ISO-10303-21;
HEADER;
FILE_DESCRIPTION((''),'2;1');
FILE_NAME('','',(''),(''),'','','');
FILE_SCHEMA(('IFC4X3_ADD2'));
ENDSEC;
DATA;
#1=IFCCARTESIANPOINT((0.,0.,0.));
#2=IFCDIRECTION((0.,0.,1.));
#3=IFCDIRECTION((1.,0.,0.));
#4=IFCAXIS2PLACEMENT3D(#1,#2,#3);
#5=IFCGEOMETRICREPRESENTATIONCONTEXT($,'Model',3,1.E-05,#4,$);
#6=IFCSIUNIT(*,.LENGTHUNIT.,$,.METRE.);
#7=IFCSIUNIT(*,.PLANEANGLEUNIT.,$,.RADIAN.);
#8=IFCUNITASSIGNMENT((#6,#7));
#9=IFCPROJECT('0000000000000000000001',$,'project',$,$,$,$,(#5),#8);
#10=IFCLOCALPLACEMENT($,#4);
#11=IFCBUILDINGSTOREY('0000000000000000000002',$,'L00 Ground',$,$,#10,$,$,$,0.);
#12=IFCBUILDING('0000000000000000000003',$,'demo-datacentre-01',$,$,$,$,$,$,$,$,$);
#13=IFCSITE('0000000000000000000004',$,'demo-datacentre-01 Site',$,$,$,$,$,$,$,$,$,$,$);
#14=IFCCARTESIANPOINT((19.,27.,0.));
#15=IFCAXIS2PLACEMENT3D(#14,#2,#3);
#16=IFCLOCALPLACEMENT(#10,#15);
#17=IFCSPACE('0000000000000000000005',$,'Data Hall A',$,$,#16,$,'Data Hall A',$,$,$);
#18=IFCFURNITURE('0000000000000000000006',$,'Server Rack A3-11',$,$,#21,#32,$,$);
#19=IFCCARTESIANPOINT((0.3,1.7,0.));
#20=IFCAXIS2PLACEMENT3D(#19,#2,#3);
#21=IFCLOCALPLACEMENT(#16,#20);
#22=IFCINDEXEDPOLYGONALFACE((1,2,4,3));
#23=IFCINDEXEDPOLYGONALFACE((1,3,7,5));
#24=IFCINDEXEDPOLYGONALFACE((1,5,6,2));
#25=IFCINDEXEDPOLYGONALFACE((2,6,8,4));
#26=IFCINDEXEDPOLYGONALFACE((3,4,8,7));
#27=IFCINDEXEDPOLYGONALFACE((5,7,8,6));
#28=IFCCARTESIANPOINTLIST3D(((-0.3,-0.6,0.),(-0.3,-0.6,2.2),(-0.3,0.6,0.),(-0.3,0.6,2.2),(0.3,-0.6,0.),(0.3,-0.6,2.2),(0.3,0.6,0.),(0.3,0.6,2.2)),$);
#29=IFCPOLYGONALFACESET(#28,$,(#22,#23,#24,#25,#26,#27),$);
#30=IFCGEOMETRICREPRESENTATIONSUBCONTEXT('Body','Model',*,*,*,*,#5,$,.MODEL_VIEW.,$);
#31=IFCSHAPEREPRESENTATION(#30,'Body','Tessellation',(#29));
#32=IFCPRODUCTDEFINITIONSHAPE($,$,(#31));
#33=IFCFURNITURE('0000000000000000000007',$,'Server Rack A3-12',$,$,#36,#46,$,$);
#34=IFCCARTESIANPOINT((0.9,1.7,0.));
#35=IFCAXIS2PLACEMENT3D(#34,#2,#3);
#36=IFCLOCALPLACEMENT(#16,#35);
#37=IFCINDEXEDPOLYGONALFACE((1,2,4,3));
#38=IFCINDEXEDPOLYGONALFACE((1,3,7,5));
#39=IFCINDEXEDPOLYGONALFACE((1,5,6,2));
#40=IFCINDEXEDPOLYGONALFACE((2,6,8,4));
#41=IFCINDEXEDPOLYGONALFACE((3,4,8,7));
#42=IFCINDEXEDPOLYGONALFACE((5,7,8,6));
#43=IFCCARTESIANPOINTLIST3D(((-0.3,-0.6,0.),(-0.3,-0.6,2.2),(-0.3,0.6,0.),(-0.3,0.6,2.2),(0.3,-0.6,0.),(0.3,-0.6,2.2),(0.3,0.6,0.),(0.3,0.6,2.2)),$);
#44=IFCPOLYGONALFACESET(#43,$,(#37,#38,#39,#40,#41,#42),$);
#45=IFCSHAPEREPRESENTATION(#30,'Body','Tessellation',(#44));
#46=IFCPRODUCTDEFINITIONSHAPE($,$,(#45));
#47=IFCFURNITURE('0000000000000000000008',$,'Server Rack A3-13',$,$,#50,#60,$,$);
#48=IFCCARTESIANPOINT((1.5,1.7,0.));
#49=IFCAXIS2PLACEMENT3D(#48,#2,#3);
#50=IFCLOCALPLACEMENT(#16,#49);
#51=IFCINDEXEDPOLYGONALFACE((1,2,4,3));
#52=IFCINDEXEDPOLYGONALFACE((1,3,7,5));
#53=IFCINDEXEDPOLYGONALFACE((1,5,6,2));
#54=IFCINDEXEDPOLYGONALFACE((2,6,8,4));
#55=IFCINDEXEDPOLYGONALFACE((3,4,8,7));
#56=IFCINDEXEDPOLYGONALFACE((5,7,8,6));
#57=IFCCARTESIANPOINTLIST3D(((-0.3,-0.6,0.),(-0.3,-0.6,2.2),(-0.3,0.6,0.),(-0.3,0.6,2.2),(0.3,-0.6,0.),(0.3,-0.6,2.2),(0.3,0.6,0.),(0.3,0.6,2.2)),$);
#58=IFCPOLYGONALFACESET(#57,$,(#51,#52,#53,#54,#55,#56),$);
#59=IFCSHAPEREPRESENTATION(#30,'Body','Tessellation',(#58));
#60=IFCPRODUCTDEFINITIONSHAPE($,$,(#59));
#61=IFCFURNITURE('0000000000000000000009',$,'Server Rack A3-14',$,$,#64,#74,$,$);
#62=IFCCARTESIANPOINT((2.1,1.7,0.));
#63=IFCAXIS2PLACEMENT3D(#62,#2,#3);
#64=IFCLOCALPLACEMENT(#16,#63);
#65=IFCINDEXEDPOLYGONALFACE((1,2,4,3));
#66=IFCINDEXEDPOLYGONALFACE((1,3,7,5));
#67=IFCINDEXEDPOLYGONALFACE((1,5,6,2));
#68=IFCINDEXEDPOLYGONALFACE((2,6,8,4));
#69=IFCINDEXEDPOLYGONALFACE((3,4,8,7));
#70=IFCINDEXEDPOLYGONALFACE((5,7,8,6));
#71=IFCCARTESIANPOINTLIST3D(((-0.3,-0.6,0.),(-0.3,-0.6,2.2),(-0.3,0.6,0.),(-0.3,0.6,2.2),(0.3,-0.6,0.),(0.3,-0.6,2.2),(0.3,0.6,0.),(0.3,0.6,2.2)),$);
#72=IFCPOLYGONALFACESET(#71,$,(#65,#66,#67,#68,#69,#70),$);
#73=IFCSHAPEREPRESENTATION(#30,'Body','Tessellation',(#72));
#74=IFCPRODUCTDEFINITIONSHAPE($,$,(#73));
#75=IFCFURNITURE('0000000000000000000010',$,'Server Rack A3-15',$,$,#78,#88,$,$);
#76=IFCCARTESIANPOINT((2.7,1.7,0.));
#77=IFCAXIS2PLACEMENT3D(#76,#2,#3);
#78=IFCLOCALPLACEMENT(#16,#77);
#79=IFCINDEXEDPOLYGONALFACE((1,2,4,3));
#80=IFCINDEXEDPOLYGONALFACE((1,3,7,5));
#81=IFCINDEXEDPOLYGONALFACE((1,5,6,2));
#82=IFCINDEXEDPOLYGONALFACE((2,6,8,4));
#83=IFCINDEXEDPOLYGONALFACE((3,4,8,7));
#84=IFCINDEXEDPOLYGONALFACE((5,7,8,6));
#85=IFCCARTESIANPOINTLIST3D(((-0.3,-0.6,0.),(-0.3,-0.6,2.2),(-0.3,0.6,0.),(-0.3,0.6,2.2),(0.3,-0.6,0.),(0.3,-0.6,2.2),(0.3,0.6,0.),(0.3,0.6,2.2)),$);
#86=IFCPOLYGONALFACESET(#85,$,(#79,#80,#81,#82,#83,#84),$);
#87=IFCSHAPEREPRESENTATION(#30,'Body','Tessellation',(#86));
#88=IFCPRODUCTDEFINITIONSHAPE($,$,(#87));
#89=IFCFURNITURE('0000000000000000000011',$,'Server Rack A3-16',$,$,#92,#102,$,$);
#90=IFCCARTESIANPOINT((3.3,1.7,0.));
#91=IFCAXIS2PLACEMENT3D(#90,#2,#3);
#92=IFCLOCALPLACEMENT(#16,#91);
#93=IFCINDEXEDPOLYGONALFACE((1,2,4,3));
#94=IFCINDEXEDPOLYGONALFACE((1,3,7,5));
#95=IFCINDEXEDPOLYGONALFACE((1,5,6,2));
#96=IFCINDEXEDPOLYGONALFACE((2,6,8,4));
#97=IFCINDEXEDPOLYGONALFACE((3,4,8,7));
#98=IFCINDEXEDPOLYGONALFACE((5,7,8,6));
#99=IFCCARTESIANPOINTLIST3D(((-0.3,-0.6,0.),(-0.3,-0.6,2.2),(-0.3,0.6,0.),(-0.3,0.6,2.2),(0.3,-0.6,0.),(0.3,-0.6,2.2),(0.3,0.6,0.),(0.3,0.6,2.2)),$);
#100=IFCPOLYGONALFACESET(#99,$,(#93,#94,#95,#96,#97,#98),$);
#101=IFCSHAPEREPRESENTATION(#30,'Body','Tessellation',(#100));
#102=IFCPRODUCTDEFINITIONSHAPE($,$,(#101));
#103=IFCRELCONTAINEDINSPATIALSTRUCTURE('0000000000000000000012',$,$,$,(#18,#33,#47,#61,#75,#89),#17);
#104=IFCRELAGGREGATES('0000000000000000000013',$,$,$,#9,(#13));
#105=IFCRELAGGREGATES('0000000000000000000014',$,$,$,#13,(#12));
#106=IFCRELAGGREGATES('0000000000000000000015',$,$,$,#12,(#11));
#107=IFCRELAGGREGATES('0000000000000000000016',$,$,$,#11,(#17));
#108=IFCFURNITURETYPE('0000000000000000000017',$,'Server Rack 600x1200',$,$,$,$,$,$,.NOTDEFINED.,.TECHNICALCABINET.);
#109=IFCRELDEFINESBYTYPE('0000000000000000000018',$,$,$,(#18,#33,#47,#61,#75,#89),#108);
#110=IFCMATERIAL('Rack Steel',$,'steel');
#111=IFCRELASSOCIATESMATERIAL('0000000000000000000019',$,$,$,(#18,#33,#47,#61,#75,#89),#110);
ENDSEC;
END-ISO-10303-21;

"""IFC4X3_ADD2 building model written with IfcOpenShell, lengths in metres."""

from ifc_helpers import new_model, si_unit, frame, origin_with_axes, place, context, subcontext, project, spatial, rectangle, extrude, material, type_object, element, save


model = new_model("IFC4X3_ADD2")

# Units and contexts
model_context = context("Model", 3, precision=1e-05, world=origin_with_axes())
body_context = subcontext(model_context, "Body", "Model", "MODEL_VIEW")
ifc_project = project(units=[si_unit("LENGTHUNIT", "METRE"), si_unit("PLANEANGLEUNIT", "RADIAN")], contexts=[model_context])

# Site, building, storey
site = spatial("IfcSite", under=ifc_project, Name="demo-datacentre-01 Site")
building = spatial("IfcBuilding", under=site, Name="demo-datacentre-01")
storey_placement = place(None, origin_with_axes())
storey = spatial("IfcBuildingStorey", under=building, at=storey_placement, Name="L00 Ground", Elevation=0.0)

# Shared definitions
space_placement = place(storey_placement, frame((19.0, 27.0, 0.0), z_axis=(0.0, 0.0, 1.0), x_axis=(1.0, 0.0, 0.0)))
space = spatial("IfcSpace", under=storey, at=space_placement, Name="Data Hall A", LongName="Data Hall A")

# Furniture
ifc_material_1 = material(Name="Rack Steel", Category="steel")
furniture_type = type_object("IfcFurnitureType", Name="Server Rack 600x1200", AssemblyPlace="NOTDEFINED", PredefinedType="TECHNICALCABINET")
for number, where, z_axis, x_axis, name in (
    (1, (0.3, 1.7, 0.0), (0.0, 0.0, 1.0), (1.0, 0.0, 0.0), "Server Rack A3-11"),
    (2, (0.9, 1.7, 0.0), (0.0, 0.0, 1.0), (1.0, 0.0, 0.0), "Server Rack A3-12"),
    (3, (1.5, 1.7, 0.0), (0.0, 0.0, 1.0), (1.0, 0.0, 0.0), "Server Rack A3-13"),
    (4, (2.1, 1.7, 0.0), (0.0, 0.0, 1.0), (1.0, 0.0, 0.0), "Server Rack A3-14"),
    (5, (2.7, 1.7, 0.0), (0.0, 0.0, 1.0), (1.0, 0.0, 0.0), "Server Rack A3-15"),
    (6, (3.3, 1.7, 0.0), (0.0, 0.0, 1.0), (1.0, 0.0, 0.0), "Server Rack A3-16"),
):
    element("IfcFurniture", number, at=place(space_placement, frame(where, z_axis=z_axis, x_axis=x_axis)), inside=space, type_object=furniture_type, material=ifc_material_1, Name=name, context=body_context, shape_type="SweptSolid", body=[
        extrude(rectangle(XDim=0.6, YDim=1.2), origin_with_axes(), (0.0, 0.0, 1.0), 2.2),
    ])

save(model, "model.ifc")
